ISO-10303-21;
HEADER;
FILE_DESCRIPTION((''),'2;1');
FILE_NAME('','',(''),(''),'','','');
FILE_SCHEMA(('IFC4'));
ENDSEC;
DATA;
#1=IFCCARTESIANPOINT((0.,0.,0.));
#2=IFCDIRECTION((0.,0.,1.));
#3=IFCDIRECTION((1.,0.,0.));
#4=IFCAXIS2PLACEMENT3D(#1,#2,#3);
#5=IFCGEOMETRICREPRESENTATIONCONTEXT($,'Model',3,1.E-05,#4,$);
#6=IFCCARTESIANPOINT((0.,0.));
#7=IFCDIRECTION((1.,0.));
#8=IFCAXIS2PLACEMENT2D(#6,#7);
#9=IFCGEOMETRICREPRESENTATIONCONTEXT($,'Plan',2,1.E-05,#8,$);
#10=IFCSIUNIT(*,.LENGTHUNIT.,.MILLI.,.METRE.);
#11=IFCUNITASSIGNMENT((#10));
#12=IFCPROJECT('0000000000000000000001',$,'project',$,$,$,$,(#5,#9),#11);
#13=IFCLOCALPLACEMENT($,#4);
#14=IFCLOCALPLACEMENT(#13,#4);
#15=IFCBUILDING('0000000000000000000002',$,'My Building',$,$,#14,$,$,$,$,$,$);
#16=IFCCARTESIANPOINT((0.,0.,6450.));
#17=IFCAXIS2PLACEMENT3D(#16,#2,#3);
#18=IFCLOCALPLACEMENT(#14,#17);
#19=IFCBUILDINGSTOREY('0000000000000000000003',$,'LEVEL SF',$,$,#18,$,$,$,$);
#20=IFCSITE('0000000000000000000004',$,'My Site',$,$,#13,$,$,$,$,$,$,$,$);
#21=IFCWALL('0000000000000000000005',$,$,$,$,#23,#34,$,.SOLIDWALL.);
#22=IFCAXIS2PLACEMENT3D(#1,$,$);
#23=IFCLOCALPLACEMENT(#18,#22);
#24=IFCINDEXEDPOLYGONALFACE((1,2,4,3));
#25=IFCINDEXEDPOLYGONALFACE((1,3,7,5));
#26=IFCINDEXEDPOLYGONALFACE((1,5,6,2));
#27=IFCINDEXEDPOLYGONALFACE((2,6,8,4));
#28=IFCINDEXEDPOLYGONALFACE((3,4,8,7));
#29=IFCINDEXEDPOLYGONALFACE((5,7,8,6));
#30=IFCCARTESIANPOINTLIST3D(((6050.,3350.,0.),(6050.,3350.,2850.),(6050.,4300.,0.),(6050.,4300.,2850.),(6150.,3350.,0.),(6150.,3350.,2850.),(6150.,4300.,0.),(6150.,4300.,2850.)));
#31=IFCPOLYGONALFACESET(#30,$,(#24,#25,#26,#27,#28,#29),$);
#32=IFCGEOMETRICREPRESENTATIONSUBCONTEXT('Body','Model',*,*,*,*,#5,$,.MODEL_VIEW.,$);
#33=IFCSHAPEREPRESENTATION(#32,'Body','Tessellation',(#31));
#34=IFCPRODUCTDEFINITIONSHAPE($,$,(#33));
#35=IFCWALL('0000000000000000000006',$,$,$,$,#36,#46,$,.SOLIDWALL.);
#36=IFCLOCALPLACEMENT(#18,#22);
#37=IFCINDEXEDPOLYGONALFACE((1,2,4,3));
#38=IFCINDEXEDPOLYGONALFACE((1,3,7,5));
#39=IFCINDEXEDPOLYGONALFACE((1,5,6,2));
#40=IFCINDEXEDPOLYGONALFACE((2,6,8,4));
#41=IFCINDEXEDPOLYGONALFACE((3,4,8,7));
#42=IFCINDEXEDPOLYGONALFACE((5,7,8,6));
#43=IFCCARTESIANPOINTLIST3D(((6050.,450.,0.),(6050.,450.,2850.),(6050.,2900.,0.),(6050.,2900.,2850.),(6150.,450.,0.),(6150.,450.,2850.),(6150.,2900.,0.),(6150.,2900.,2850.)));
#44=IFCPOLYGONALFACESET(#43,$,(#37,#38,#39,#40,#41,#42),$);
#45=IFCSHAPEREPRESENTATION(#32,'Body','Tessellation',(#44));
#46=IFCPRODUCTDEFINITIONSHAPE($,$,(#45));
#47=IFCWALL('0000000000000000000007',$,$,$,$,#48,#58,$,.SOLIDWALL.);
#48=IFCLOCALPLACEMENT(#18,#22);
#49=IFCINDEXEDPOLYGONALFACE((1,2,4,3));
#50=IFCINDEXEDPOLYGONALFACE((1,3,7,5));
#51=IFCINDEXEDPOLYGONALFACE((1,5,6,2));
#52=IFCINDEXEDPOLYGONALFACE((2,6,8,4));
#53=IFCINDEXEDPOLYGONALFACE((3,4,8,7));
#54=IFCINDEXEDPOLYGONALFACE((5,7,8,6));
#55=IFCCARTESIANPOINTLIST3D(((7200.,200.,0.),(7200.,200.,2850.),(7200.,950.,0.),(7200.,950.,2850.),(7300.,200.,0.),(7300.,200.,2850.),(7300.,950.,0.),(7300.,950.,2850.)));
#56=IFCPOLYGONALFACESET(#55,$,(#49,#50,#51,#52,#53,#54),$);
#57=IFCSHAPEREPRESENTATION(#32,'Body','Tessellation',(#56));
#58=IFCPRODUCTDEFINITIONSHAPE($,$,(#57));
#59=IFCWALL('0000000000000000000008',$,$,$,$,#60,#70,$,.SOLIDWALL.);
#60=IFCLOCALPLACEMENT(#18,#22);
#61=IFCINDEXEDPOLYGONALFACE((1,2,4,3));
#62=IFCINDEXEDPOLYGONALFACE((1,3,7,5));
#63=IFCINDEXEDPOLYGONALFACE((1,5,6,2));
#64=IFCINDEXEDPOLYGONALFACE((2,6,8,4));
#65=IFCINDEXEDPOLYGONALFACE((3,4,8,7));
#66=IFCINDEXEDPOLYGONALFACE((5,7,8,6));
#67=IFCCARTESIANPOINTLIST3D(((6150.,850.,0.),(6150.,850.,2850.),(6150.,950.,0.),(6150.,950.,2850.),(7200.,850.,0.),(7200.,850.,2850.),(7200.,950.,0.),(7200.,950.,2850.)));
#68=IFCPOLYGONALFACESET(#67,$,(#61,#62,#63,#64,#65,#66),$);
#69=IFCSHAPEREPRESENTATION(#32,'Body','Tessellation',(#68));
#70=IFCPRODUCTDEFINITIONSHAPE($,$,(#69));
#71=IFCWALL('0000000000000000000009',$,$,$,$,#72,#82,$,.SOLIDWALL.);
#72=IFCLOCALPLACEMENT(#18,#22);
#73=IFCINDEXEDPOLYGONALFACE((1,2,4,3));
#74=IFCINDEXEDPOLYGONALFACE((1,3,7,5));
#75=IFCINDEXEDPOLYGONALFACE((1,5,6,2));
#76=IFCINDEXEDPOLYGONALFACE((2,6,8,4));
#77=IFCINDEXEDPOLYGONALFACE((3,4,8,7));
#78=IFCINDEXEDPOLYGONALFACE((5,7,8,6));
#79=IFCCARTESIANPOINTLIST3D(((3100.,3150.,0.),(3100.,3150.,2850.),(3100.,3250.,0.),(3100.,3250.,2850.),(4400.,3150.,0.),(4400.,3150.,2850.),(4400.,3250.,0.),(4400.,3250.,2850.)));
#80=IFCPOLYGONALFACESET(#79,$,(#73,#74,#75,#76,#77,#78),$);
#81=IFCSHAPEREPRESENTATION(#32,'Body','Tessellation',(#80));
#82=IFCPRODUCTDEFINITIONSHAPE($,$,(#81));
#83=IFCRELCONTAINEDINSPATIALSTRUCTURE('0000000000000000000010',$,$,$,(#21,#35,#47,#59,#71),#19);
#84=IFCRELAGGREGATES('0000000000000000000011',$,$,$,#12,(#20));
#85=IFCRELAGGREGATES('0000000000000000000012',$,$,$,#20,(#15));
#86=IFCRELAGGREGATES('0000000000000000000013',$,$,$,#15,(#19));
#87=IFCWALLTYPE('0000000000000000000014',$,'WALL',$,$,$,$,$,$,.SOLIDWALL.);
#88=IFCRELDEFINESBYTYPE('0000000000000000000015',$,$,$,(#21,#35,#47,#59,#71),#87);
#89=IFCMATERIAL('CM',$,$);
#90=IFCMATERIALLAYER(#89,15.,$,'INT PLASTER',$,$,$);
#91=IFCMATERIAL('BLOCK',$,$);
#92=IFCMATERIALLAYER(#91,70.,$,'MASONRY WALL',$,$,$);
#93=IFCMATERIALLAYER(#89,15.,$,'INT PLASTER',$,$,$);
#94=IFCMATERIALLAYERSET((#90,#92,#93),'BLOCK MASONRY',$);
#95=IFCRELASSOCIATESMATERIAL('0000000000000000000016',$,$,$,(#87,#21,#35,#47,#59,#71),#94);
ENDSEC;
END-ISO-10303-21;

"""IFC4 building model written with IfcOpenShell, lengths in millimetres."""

from ifc_helpers import new_model, si_unit, frame, origin_with_axes, origin_2d_with_axis, place, context, subcontext, project, spatial, indexed_curve, outline, extrude, material, layer, layer_set, layer_usage, type_object, element, save


model = new_model("IFC4")

# Units and contexts
model_context = context("Model", 3, precision=1e-05, world=origin_with_axes())
plan_context = context("Plan", 2, precision=1e-05, world=origin_2d_with_axis())
body_context = subcontext(model_context, "Body", "Model", "MODEL_VIEW")
ifc_project = project(units=[si_unit("LENGTHUNIT", "METRE", prefix="MILLI")], contexts=[model_context, plan_context])

# Site, building, storey
site_placement = place(None, origin_with_axes())
site = spatial("IfcSite", under=ifc_project, at=site_placement, Name="My Site")
building_placement = place(site_placement, origin_with_axes())
building = spatial("IfcBuilding", under=site, at=building_placement, Name="My Building")
storey_placement = place(building_placement, frame((0.0, 0.0, 6450.0), z_axis=(0.0, 0.0, 1.0), x_axis=(1.0, 0.0, 0.0)))
storey = spatial("IfcBuildingStorey", under=building, at=storey_placement, Name="LEVEL SF")

# Shared definitions
ifc_material_1 = material(Name="CM")
ifc_layer_1 = layer(ifc_material_1, 15.0, Name="INT PLASTER")
ifc_material_2 = material(Name="BLOCK")
ifc_layer_2 = layer(ifc_material_2, 70.0, Name="MASONRY WALL")
ifc_layer_3 = layer(ifc_material_1, 15.0, Name="INT PLASTER")
ifc_layer_set_1 = layer_set([ifc_layer_1, ifc_layer_2, ifc_layer_3], Name="BLOCK MASONRY")
wall_type = type_object("IfcWallType", Name="WALL", PredefinedType="SOLIDWALL", material=ifc_layer_set_1)

# Walls
ifc_layer_usage_1 = layer_usage(ifc_layer_set_1, "AXIS2", "POSITIVE", 0.0)
wall_1_placement = place(storey_placement, frame((6150.0, 3350.0, 0.0), z_axis=(0.0, 0.0, 1.0), x_axis=(0.0, 1.0, 0.0)))
element("IfcWall", 1, at=wall_1_placement, inside=storey, type_object=wall_type, material=ifc_layer_usage_1, PredefinedType="SOLIDWALL", context=body_context, shape_type="SweptSolid", body=[
    extrude(outline(indexed_curve([(0.0, 0.0), (0.0, 100.0), (950.0, 100.0), (950.0, 0.0), (0.0, 0.0)], self_intersect=False)), origin_with_axes(), (0.0, 0.0, 1.0), 2850.0),
])
ifc_layer_usage_2 = layer_usage(ifc_layer_set_1, "AXIS2", "POSITIVE", 0.0)
wall_2_placement = place(storey_placement, frame((6150.0, 450.0, 0.0), z_axis=(0.0, 0.0, 1.0), x_axis=(0.0, 1.0, 0.0)))
element("IfcWall", 2, at=wall_2_placement, inside=storey, type_object=wall_type, material=ifc_layer_usage_2, PredefinedType="SOLIDWALL", context=body_context, shape_type="SweptSolid", body=[
    extrude(outline(indexed_curve([(0.0, 0.0), (0.0, 100.0), (2450.0, 100.0), (2450.0, 0.0), (0.0, 0.0)], self_intersect=False)), origin_with_axes(), (0.0, 0.0, 1.0), 2850.0),
])
ifc_layer_usage_3 = layer_usage(ifc_layer_set_1, "AXIS2", "POSITIVE", 0.0)
wall_3_placement = place(storey_placement, frame((7300.0, 200.0, 0.0), z_axis=(0.0, 0.0, 1.0), x_axis=(0.0, 1.0, 0.0)))
element("IfcWall", 3, at=wall_3_placement, inside=storey, type_object=wall_type, material=ifc_layer_usage_3, PredefinedType="SOLIDWALL", context=body_context, shape_type="SweptSolid", body=[
    extrude(outline(indexed_curve([(0.0, 0.0), (0.0, 100.0), (750.0, 100.0), (750.0, 0.0), (0.0, 0.0)], self_intersect=False)), origin_with_axes(), (0.0, 0.0, 1.0), 2850.0),
])
ifc_layer_usage_4 = layer_usage(ifc_layer_set_1, "AXIS2", "POSITIVE", 0.0)
wall_4_placement = place(storey_placement, frame((6150.0, 950.0, 0.0), z_axis=(0.0, 0.0, 1.0), x_axis=(0.0, -1.0, 0.0)))
element("IfcWall", 4, at=wall_4_placement, inside=storey, type_object=wall_type, material=ifc_layer_usage_4, PredefinedType="SOLIDWALL", context=body_context, shape_type="SweptSolid", body=[
    extrude(outline(indexed_curve([(0.0, 0.0), (0.0, 1050.0), (100.0, 1050.0), (100.0, 0.0), (0.0, 0.0)], self_intersect=False)), origin_with_axes(), (0.0, 0.0, 1.0), 2850.0),
])
ifc_layer_usage_5 = layer_usage(ifc_layer_set_1, "AXIS2", "POSITIVE", 0.0)
wall_5_placement = place(storey_placement, frame((3100.0, 3250.0, 0.0), z_axis=(0.0, 0.0, 1.0), x_axis=(0.0, -1.0, 0.0)))
element("IfcWall", 5, at=wall_5_placement, inside=storey, type_object=wall_type, material=ifc_layer_usage_5, PredefinedType="SOLIDWALL", context=body_context, shape_type="SweptSolid", body=[
    extrude(outline(indexed_curve([(0.0, 0.0), (0.0, 1300.0), (100.0, 1300.0), (100.0, 0.0), (0.0, 0.0)], self_intersect=False)), origin_with_axes(), (0.0, 0.0, 1.0), 2850.0),
])

save(model, "model.ifc")
